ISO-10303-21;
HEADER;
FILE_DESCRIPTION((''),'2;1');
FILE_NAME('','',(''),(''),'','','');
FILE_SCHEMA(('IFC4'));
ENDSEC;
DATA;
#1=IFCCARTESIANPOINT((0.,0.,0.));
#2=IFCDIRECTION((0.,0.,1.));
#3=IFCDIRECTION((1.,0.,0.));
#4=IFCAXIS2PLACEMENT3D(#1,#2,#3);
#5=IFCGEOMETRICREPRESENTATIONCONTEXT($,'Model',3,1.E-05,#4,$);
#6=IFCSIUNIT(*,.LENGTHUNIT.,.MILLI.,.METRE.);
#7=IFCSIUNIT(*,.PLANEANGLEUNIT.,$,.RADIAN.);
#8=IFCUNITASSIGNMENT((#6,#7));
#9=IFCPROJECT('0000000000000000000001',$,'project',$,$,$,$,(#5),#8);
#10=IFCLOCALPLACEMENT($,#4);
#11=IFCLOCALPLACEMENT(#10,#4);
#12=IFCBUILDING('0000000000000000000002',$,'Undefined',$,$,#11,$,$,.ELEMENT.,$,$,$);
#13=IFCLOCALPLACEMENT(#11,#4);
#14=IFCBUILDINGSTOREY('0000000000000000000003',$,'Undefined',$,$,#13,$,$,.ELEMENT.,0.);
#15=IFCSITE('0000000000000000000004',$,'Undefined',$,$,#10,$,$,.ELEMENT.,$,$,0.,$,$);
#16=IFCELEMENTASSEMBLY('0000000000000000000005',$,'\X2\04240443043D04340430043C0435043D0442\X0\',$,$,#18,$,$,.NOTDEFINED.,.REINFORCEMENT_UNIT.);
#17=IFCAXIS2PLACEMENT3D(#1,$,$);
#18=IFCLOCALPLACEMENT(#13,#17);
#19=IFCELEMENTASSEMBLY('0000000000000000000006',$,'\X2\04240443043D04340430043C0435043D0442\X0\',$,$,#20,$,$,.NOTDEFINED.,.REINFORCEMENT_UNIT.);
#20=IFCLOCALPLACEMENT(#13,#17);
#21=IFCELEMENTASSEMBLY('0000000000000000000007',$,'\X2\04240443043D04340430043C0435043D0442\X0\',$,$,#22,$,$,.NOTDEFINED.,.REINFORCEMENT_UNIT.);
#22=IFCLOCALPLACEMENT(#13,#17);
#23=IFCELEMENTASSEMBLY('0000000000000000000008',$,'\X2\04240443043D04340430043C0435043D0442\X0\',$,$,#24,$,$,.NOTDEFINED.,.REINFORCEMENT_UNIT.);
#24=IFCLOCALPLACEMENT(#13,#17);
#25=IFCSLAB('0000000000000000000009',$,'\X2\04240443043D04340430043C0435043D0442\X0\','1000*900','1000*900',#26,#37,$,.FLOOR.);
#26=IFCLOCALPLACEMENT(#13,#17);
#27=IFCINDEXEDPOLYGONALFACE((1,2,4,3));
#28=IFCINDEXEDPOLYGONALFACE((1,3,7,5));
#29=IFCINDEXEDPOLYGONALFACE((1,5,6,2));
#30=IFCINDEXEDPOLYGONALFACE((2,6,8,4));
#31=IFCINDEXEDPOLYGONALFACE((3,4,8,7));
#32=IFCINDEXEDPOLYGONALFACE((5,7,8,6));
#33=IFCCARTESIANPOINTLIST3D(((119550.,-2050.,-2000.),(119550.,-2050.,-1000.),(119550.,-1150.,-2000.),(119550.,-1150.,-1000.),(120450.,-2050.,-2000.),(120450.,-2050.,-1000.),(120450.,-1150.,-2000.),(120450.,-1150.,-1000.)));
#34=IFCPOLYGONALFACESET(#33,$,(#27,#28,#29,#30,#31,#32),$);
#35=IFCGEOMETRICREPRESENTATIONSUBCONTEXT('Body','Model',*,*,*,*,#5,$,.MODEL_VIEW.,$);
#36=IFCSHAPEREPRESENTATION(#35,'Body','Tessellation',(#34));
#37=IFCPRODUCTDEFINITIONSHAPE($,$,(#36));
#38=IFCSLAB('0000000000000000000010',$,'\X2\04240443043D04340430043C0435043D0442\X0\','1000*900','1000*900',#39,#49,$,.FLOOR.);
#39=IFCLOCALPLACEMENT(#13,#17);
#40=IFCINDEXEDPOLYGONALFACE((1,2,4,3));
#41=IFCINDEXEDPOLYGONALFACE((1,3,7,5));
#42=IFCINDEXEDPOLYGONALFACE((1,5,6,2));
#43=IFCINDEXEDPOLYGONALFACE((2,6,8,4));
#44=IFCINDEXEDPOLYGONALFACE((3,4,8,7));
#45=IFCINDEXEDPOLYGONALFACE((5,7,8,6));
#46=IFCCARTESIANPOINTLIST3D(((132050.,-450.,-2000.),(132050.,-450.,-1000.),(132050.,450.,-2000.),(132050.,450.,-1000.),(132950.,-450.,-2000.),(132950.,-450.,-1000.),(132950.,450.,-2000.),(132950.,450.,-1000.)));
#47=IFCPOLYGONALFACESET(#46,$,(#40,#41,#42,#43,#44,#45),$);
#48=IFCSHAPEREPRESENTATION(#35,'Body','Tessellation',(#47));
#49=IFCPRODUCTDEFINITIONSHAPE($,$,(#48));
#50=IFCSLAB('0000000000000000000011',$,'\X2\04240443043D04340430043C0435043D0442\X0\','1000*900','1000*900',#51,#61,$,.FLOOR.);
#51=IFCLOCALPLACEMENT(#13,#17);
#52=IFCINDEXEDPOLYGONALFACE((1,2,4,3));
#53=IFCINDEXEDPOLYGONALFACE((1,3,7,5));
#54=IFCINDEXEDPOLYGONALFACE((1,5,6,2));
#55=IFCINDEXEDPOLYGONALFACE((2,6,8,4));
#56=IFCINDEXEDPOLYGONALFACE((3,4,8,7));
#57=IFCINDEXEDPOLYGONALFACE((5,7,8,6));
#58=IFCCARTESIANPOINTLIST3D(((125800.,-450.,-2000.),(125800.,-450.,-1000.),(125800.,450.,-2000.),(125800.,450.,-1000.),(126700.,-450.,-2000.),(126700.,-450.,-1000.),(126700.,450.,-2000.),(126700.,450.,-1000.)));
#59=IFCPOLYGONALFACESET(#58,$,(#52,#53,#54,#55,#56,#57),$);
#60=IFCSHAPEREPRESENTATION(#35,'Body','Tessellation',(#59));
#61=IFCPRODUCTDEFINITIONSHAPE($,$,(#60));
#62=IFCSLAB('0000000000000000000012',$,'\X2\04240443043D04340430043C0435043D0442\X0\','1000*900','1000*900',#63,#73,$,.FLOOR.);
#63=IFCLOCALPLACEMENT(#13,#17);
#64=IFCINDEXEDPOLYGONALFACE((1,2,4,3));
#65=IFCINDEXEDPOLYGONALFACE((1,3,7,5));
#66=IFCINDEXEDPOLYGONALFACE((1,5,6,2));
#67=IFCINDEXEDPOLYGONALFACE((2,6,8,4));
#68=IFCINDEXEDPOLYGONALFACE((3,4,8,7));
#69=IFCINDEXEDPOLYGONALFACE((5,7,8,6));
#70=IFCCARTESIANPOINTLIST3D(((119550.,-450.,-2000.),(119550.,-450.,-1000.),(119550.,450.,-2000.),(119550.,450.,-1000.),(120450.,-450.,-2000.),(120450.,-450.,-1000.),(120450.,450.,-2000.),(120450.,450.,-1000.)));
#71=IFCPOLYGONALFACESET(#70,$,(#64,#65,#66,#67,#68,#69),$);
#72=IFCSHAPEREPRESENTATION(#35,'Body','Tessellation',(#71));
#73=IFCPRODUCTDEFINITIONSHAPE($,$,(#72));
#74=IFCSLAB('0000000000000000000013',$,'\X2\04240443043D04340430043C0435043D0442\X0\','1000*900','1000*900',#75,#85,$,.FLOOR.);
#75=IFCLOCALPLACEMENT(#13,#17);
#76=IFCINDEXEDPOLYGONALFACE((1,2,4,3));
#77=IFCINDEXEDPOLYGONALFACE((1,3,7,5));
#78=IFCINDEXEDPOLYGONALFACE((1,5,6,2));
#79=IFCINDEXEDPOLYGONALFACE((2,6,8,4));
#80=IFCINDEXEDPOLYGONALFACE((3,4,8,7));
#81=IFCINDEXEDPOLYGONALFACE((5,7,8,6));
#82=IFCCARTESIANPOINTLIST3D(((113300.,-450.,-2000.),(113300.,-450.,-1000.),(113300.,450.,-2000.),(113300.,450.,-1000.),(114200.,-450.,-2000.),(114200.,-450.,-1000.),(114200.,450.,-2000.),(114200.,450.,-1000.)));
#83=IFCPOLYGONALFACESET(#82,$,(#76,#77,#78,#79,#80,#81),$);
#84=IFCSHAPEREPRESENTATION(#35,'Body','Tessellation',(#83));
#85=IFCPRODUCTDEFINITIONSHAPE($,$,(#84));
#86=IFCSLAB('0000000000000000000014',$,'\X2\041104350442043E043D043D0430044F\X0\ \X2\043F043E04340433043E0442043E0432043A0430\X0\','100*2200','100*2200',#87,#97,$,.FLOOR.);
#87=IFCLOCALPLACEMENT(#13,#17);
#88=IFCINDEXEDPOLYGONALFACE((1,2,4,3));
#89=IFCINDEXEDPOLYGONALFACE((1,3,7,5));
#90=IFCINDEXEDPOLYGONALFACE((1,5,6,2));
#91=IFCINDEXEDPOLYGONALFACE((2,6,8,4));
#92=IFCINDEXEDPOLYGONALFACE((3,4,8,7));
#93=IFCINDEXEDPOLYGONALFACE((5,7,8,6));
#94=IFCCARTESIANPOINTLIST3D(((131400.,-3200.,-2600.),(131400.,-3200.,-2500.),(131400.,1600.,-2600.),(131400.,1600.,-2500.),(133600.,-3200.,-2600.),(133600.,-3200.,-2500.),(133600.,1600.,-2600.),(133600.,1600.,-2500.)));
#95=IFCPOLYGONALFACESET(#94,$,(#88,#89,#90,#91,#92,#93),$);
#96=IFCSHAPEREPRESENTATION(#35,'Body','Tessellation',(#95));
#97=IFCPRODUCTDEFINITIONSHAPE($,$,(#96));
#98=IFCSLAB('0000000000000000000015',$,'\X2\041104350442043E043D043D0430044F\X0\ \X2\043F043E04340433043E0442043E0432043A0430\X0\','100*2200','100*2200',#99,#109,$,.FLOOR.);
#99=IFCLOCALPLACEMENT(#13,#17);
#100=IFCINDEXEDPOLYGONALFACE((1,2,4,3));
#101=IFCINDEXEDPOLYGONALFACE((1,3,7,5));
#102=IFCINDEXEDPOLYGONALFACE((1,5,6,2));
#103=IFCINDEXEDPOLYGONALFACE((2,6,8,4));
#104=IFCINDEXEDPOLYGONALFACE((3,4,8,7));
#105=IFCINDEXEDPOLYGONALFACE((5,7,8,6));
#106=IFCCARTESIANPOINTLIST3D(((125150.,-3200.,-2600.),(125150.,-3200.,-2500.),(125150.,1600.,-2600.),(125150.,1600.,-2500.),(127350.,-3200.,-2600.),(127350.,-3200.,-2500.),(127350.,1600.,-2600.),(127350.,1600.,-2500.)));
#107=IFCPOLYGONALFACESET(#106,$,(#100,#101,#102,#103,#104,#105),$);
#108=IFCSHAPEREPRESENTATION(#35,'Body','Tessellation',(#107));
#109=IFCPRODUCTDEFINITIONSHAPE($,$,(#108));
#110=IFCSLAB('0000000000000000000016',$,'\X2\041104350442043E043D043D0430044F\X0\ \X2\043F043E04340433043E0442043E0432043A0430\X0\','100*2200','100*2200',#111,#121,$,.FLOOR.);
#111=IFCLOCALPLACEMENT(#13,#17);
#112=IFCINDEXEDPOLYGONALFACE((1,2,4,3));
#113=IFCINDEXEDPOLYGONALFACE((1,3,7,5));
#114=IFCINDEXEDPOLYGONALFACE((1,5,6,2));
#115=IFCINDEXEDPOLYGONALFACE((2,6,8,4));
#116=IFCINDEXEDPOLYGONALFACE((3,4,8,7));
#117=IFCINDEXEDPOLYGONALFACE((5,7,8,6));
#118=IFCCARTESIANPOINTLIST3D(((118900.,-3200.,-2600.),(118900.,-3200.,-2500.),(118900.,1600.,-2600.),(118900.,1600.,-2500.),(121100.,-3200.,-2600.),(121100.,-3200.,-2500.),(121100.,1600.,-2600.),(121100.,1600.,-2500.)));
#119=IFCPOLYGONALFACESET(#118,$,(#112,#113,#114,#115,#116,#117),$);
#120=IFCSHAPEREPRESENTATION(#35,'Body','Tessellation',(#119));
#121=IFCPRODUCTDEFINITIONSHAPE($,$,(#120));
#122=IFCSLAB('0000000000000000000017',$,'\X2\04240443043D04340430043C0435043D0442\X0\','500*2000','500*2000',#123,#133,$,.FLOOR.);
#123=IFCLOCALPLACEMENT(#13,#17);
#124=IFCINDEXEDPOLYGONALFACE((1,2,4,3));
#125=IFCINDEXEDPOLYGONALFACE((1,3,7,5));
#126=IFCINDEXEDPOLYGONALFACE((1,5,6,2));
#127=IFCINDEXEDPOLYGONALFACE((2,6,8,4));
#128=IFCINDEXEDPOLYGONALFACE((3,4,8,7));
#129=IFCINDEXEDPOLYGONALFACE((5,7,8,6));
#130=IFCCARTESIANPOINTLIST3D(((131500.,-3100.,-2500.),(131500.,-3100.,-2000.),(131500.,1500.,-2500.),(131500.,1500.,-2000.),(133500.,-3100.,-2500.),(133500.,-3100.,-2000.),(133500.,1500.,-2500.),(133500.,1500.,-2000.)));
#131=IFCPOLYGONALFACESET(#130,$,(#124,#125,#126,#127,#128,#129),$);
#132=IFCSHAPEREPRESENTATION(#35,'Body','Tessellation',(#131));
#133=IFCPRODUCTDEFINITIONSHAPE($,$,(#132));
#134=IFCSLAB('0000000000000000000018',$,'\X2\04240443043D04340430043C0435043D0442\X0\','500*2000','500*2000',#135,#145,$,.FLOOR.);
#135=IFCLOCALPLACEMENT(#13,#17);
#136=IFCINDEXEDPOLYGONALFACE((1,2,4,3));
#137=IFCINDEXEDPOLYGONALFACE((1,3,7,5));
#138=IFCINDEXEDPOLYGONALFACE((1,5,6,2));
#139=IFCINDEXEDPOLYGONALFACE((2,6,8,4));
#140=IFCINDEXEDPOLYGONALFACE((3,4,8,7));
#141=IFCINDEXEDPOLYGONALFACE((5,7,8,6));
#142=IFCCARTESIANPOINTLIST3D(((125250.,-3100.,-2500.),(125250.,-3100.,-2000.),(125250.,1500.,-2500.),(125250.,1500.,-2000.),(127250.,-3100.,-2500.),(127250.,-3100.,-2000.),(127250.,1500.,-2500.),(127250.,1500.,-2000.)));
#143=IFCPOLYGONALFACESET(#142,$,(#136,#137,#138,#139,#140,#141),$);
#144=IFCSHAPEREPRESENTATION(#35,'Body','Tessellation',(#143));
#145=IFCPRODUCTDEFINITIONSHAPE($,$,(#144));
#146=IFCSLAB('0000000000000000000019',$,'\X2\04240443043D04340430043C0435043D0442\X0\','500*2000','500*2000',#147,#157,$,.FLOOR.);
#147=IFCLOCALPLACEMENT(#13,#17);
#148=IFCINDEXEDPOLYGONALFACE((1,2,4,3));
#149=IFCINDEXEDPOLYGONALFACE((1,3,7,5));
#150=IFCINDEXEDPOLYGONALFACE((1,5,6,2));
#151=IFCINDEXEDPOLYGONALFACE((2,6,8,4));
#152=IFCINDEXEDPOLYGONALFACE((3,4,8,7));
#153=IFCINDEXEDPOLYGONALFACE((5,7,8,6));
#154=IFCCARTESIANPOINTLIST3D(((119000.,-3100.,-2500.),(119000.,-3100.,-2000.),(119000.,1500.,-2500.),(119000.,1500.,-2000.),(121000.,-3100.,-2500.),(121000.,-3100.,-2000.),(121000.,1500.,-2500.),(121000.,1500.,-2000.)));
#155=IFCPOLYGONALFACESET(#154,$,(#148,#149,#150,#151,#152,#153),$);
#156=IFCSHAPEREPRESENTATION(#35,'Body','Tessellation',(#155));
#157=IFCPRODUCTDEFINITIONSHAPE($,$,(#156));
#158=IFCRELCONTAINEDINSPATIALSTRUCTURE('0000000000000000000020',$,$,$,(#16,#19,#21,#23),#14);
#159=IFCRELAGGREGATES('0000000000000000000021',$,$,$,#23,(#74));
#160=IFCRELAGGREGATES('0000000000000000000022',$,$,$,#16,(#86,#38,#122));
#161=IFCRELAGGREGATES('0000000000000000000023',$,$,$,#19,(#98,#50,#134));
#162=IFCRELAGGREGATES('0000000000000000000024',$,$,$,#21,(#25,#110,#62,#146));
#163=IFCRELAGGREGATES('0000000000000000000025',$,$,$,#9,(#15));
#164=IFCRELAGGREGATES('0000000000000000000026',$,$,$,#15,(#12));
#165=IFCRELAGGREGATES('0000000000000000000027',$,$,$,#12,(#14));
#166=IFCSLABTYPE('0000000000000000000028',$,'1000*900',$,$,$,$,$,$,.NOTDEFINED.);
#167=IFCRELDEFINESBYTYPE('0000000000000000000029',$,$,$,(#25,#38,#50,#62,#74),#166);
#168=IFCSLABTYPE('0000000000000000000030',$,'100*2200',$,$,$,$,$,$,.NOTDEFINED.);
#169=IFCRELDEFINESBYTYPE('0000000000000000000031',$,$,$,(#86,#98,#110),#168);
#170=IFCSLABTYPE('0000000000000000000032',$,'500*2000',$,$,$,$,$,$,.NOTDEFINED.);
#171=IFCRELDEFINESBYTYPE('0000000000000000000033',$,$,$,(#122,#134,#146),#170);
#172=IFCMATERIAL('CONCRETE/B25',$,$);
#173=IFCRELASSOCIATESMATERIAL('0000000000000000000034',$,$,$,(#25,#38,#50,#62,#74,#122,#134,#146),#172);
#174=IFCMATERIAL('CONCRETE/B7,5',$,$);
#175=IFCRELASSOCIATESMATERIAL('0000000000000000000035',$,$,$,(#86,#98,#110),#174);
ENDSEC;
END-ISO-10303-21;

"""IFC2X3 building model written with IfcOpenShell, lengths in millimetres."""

from ifc_helpers import new_model, si_unit, frame, origin_with_axes, place, context, subcontext, project, spatial, polyline, outline, extrude, material, type_object, element, aggregate, save


model = new_model("IFC2X3")

# Units and contexts
model_context = context("Model", 3, precision=1e-05, world=origin_with_axes())
body_context = subcontext(model_context, "Body", "Model", "MODEL_VIEW")
ifc_project = project(units=[si_unit("LENGTHUNIT", "METRE", prefix="MILLI"), si_unit("PLANEANGLEUNIT", "RADIAN")], contexts=[model_context])

# Site, building, storey
site_placement = place(None, origin_with_axes())
site = spatial("IfcSite", under=ifc_project, at=site_placement, Name="Undefined", CompositionType="ELEMENT", RefElevation=0.0)
building_placement = place(site_placement, origin_with_axes())
building = spatial("IfcBuilding", under=site, at=building_placement, Name="Undefined", CompositionType="ELEMENT")
storey_placement = place(building_placement, origin_with_axes())
storey = spatial("IfcBuildingStorey", under=building, at=storey_placement, Name="Undefined", CompositionType="ELEMENT", Elevation=0.0)

# Element assemblies
assembly_1_placement = place(storey_placement, origin_with_axes())
assembly_1 = element("IfcElementAssembly", 1, at=assembly_1_placement, inside=storey, Name="Фундамент", AssemblyPlace="NOTDEFINED", PredefinedType="REINFORCEMENT_UNIT")
ifc_material_1 = material(Name="CONCRETE/B25")
assembly_2_placement = place(storey_placement, origin_with_axes())
assembly_2 = element("IfcElementAssembly", 2, at=assembly_2_placement, inside=storey, Name="Фундамент", AssemblyPlace="NOTDEFINED", PredefinedType="REINFORCEMENT_UNIT")
assembly_3_placement = place(storey_placement, origin_with_axes())
assembly_3 = element("IfcElementAssembly", 3, at=assembly_3_placement, inside=storey, Name="Фундамент", AssemblyPlace="NOTDEFINED", PredefinedType="REINFORCEMENT_UNIT")
assembly_4_placement = place(storey_placement, origin_with_axes())
assembly_4 = element("IfcElementAssembly", 4, at=assembly_4_placement, inside=storey, Name="Фундамент", AssemblyPlace="NOTDEFINED", PredefinedType="REINFORCEMENT_UNIT")

# Slabs
slab_type_1 = type_object("IfcSlabType", Name="1000*900", PredefinedType="NOTDEFINED")
slab_1_placement = place(assembly_3_placement, frame((119550.0, -1150.0, -1500.0), z_axis=(0.0, 0.0, 1.0), x_axis=(0.0, -1.0, 0.0)))
slab_1 = element("IfcSlab", 5, at=slab_1_placement, type_object=slab_type_1, material=ifc_material_1, Name="Фундамент", Description="1000*900", ObjectType="1000*900", PredefinedType="FLOOR", context=body_context, shape_type="SweptSolid", body=[
    extrude(outline(polyline([(0.0, 0.0), (900.0, 0.0), (900.0, 900.0), (0.0, 900.0), (0.0, 0.0)])), frame((0.0, 0.0, -500.0), z_axis=(0.0, 0.0, 1.0), x_axis=(1.0, 0.0, 0.0)), (0.0, 0.0, 1.0), 1000.0),
])
slab_2_placement = place(assembly_1_placement, frame((132050.0, 450.0, -1500.0), z_axis=(0.0, 0.0, 1.0), x_axis=(0.0, -1.0, 0.0)))
slab_2 = element("IfcSlab", 6, at=slab_2_placement, type_object=slab_type_1, material=ifc_material_1, Name="Фундамент", Description="1000*900", ObjectType="1000*900", PredefinedType="FLOOR", context=body_context, shape_type="SweptSolid", body=[
    extrude(outline(polyline([(0.0, 0.0), (900.0, 0.0), (900.0, 900.0), (0.0, 900.0), (0.0, 0.0)])), frame((0.0, 0.0, -500.0), z_axis=(0.0, 0.0, 1.0), x_axis=(1.0, 0.0, 0.0)), (0.0, 0.0, 1.0), 1000.0),
])
slab_3_placement = place(assembly_2_placement, frame((125800.0, 450.0, -1500.0), z_axis=(0.0, 0.0, 1.0), x_axis=(0.0, -1.0, 0.0)))
slab_3 = element("IfcSlab", 7, at=slab_3_placement, type_object=slab_type_1, material=ifc_material_1, Name="Фундамент", Description="1000*900", ObjectType="1000*900", PredefinedType="FLOOR", context=body_context, shape_type="SweptSolid", body=[
    extrude(outline(polyline([(0.0, 0.0), (900.0, 0.0), (900.0, 900.0), (0.0, 900.0), (0.0, 0.0)])), frame((0.0, 0.0, -500.0), z_axis=(0.0, 0.0, 1.0), x_axis=(1.0, 0.0, 0.0)), (0.0, 0.0, 1.0), 1000.0),
])
slab_4_placement = place(assembly_3_placement, frame((119550.0, 450.0, -1500.0), z_axis=(0.0, 0.0, 1.0), x_axis=(0.0, -1.0, 0.0)))
slab_4 = element("IfcSlab", 8, at=slab_4_placement, type_object=slab_type_1, material=ifc_material_1, Name="Фундамент", Description="1000*900", ObjectType="1000*900", PredefinedType="FLOOR", context=body_context, shape_type="SweptSolid", body=[
    extrude(outline(polyline([(0.0, 0.0), (900.0, 0.0), (900.0, 900.0), (0.0, 900.0), (0.0, 0.0)])), frame((0.0, 0.0, -500.0), z_axis=(0.0, 0.0, 1.0), x_axis=(1.0, 0.0, 0.0)), (0.0, 0.0, 1.0), 1000.0),
])
slab_5_placement = place(assembly_4_placement, frame((113300.0, 450.0, -1500.0), z_axis=(0.0, 0.0, 1.0), x_axis=(0.0, -1.0, 0.0)))
slab_5 = element("IfcSlab", 9, at=slab_5_placement, type_object=slab_type_1, material=ifc_material_1, Name="Фундамент", Description="1000*900", ObjectType="1000*900", PredefinedType="FLOOR", context=body_context, shape_type="SweptSolid", body=[
    extrude(outline(polyline([(0.0, 0.0), (900.0, 0.0), (900.0, 900.0), (0.0, 900.0), (0.0, 0.0)])), frame((0.0, 0.0, -500.0), z_axis=(0.0, 0.0, 1.0), x_axis=(1.0, 0.0, 0.0)), (0.0, 0.0, 1.0), 1000.0),
])
aggregate(assembly_4, [slab_5])
ifc_material_2 = material(Name="CONCRETE/B7,5")
slab_type_2 = type_object("IfcSlabType", Name="100*2200", PredefinedType="NOTDEFINED")
slab_6_placement = place(assembly_1_placement, frame((131400.0, 1600.0, -2550.0), z_axis=(0.0, 0.0, 1.0), x_axis=(0.0, -1.0, 0.0)))
slab_6 = element("IfcSlab", 10, at=slab_6_placement, type_object=slab_type_2, material=ifc_material_2, Name="Бетонная подготовка", Description="100*2200", ObjectType="100*2200", PredefinedType="FLOOR", context=body_context, shape_type="SweptSolid", body=[
    extrude(outline(polyline([(0.0, 0.0), (4800.0, 0.0), (4800.0, 2200.0), (0.0, 2200.0), (0.0, 0.0)])), frame((0.0, 0.0, -50.0), z_axis=(0.0, 0.0, 1.0), x_axis=(1.0, 0.0, 0.0)), (0.0, 0.0, 1.0), 100.0),
])
slab_7_placement = place(assembly_2_placement, frame((125150.0, 1600.0, -2550.0), z_axis=(0.0, 0.0, 1.0), x_axis=(0.0, -1.0, 0.0)))
slab_7 = element("IfcSlab", 11, at=slab_7_placement, type_object=slab_type_2, material=ifc_material_2, Name="Бетонная подготовка", Description="100*2200", ObjectType="100*2200", PredefinedType="FLOOR", context=body_context, shape_type="SweptSolid", body=[
    extrude(outline(polyline([(0.0, 0.0), (4800.0, 0.0), (4800.0, 2200.0), (0.0, 2200.0), (0.0, 0.0)])), frame((0.0, 0.0, -50.0), z_axis=(0.0, 0.0, 1.0), x_axis=(1.0, 0.0, 0.0)), (0.0, 0.0, 1.0), 100.0),
])
slab_8_placement = place(assembly_3_placement, frame((118900.0, 1600.0, -2550.0), z_axis=(0.0, 0.0, 1.0), x_axis=(0.0, -1.0, 0.0)))
slab_8 = element("IfcSlab", 12, at=slab_8_placement, type_object=slab_type_2, material=ifc_material_2, Name="Бетонная подготовка", Description="100*2200", ObjectType="100*2200", PredefinedType="FLOOR", context=body_context, shape_type="SweptSolid", body=[
    extrude(outline(polyline([(0.0, 0.0), (4800.0, 0.0), (4800.0, 2200.0), (0.0, 2200.0), (0.0, 0.0)])), frame((0.0, 0.0, -50.0), z_axis=(0.0, 0.0, 1.0), x_axis=(1.0, 0.0, 0.0)), (0.0, 0.0, 1.0), 100.0),
])
slab_type_3 = type_object("IfcSlabType", Name="500*2000", PredefinedType="NOTDEFINED")
slab_9_placement = place(assembly_1_placement, frame((131500.0, 1500.0, -2250.0), z_axis=(0.0, 0.0, 1.0), x_axis=(0.0, -1.0, 0.0)))
slab_9 = element("IfcSlab", 13, at=slab_9_placement, type_object=slab_type_3, material=ifc_material_1, Name="Фундамент", Description="500*2000", ObjectType="500*2000", PredefinedType="FLOOR", context=body_context, shape_type="SweptSolid", body=[
    extrude(outline(polyline([(0.0, 0.0), (4600.0, 0.0), (4600.0, 2000.0), (0.0, 2000.0), (0.0, 0.0)])), frame((0.0, 0.0, -250.0), z_axis=(0.0, 0.0, 1.0), x_axis=(1.0, 0.0, 0.0)), (0.0, 0.0, 1.0), 500.0),
])
aggregate(assembly_1, [slab_6, slab_2, slab_9])
slab_10_placement = place(assembly_2_placement, frame((125250.0, 1500.0, -2250.0), z_axis=(0.0, 0.0, 1.0), x_axis=(0.0, -1.0, 0.0)))
slab_10 = element("IfcSlab", 14, at=slab_10_placement, type_object=slab_type_3, material=ifc_material_1, Name="Фундамент", Description="500*2000", ObjectType="500*2000", PredefinedType="FLOOR", context=body_context, shape_type="SweptSolid", body=[
    extrude(outline(polyline([(0.0, 0.0), (4600.0, 0.0), (4600.0, 2000.0), (0.0, 2000.0), (0.0, 0.0)])), frame((0.0, 0.0, -250.0), z_axis=(0.0, 0.0, 1.0), x_axis=(1.0, 0.0, 0.0)), (0.0, 0.0, 1.0), 500.0),
])
aggregate(assembly_2, [slab_7, slab_3, slab_10])
slab_11_placement = place(assembly_3_placement, frame((119000.0, 1500.0, -2250.0), z_axis=(0.0, 0.0, 1.0), x_axis=(0.0, -1.0, 0.0)))
slab_11 = element("IfcSlab", 15, at=slab_11_placement, type_object=slab_type_3, material=ifc_material_1, Name="Фундамент", Description="500*2000", ObjectType="500*2000", PredefinedType="FLOOR", context=body_context, shape_type="SweptSolid", body=[
    extrude(outline(polyline([(0.0, 0.0), (4600.0, 0.0), (4600.0, 2000.0), (0.0, 2000.0), (0.0, 0.0)])), frame((0.0, 0.0, -250.0), z_axis=(0.0, 0.0, 1.0), x_axis=(1.0, 0.0, 0.0)), (0.0, 0.0, 1.0), 500.0),
])
aggregate(assembly_3, [slab_1, slab_8, slab_4, slab_11])

save(model, "model.ifc")
